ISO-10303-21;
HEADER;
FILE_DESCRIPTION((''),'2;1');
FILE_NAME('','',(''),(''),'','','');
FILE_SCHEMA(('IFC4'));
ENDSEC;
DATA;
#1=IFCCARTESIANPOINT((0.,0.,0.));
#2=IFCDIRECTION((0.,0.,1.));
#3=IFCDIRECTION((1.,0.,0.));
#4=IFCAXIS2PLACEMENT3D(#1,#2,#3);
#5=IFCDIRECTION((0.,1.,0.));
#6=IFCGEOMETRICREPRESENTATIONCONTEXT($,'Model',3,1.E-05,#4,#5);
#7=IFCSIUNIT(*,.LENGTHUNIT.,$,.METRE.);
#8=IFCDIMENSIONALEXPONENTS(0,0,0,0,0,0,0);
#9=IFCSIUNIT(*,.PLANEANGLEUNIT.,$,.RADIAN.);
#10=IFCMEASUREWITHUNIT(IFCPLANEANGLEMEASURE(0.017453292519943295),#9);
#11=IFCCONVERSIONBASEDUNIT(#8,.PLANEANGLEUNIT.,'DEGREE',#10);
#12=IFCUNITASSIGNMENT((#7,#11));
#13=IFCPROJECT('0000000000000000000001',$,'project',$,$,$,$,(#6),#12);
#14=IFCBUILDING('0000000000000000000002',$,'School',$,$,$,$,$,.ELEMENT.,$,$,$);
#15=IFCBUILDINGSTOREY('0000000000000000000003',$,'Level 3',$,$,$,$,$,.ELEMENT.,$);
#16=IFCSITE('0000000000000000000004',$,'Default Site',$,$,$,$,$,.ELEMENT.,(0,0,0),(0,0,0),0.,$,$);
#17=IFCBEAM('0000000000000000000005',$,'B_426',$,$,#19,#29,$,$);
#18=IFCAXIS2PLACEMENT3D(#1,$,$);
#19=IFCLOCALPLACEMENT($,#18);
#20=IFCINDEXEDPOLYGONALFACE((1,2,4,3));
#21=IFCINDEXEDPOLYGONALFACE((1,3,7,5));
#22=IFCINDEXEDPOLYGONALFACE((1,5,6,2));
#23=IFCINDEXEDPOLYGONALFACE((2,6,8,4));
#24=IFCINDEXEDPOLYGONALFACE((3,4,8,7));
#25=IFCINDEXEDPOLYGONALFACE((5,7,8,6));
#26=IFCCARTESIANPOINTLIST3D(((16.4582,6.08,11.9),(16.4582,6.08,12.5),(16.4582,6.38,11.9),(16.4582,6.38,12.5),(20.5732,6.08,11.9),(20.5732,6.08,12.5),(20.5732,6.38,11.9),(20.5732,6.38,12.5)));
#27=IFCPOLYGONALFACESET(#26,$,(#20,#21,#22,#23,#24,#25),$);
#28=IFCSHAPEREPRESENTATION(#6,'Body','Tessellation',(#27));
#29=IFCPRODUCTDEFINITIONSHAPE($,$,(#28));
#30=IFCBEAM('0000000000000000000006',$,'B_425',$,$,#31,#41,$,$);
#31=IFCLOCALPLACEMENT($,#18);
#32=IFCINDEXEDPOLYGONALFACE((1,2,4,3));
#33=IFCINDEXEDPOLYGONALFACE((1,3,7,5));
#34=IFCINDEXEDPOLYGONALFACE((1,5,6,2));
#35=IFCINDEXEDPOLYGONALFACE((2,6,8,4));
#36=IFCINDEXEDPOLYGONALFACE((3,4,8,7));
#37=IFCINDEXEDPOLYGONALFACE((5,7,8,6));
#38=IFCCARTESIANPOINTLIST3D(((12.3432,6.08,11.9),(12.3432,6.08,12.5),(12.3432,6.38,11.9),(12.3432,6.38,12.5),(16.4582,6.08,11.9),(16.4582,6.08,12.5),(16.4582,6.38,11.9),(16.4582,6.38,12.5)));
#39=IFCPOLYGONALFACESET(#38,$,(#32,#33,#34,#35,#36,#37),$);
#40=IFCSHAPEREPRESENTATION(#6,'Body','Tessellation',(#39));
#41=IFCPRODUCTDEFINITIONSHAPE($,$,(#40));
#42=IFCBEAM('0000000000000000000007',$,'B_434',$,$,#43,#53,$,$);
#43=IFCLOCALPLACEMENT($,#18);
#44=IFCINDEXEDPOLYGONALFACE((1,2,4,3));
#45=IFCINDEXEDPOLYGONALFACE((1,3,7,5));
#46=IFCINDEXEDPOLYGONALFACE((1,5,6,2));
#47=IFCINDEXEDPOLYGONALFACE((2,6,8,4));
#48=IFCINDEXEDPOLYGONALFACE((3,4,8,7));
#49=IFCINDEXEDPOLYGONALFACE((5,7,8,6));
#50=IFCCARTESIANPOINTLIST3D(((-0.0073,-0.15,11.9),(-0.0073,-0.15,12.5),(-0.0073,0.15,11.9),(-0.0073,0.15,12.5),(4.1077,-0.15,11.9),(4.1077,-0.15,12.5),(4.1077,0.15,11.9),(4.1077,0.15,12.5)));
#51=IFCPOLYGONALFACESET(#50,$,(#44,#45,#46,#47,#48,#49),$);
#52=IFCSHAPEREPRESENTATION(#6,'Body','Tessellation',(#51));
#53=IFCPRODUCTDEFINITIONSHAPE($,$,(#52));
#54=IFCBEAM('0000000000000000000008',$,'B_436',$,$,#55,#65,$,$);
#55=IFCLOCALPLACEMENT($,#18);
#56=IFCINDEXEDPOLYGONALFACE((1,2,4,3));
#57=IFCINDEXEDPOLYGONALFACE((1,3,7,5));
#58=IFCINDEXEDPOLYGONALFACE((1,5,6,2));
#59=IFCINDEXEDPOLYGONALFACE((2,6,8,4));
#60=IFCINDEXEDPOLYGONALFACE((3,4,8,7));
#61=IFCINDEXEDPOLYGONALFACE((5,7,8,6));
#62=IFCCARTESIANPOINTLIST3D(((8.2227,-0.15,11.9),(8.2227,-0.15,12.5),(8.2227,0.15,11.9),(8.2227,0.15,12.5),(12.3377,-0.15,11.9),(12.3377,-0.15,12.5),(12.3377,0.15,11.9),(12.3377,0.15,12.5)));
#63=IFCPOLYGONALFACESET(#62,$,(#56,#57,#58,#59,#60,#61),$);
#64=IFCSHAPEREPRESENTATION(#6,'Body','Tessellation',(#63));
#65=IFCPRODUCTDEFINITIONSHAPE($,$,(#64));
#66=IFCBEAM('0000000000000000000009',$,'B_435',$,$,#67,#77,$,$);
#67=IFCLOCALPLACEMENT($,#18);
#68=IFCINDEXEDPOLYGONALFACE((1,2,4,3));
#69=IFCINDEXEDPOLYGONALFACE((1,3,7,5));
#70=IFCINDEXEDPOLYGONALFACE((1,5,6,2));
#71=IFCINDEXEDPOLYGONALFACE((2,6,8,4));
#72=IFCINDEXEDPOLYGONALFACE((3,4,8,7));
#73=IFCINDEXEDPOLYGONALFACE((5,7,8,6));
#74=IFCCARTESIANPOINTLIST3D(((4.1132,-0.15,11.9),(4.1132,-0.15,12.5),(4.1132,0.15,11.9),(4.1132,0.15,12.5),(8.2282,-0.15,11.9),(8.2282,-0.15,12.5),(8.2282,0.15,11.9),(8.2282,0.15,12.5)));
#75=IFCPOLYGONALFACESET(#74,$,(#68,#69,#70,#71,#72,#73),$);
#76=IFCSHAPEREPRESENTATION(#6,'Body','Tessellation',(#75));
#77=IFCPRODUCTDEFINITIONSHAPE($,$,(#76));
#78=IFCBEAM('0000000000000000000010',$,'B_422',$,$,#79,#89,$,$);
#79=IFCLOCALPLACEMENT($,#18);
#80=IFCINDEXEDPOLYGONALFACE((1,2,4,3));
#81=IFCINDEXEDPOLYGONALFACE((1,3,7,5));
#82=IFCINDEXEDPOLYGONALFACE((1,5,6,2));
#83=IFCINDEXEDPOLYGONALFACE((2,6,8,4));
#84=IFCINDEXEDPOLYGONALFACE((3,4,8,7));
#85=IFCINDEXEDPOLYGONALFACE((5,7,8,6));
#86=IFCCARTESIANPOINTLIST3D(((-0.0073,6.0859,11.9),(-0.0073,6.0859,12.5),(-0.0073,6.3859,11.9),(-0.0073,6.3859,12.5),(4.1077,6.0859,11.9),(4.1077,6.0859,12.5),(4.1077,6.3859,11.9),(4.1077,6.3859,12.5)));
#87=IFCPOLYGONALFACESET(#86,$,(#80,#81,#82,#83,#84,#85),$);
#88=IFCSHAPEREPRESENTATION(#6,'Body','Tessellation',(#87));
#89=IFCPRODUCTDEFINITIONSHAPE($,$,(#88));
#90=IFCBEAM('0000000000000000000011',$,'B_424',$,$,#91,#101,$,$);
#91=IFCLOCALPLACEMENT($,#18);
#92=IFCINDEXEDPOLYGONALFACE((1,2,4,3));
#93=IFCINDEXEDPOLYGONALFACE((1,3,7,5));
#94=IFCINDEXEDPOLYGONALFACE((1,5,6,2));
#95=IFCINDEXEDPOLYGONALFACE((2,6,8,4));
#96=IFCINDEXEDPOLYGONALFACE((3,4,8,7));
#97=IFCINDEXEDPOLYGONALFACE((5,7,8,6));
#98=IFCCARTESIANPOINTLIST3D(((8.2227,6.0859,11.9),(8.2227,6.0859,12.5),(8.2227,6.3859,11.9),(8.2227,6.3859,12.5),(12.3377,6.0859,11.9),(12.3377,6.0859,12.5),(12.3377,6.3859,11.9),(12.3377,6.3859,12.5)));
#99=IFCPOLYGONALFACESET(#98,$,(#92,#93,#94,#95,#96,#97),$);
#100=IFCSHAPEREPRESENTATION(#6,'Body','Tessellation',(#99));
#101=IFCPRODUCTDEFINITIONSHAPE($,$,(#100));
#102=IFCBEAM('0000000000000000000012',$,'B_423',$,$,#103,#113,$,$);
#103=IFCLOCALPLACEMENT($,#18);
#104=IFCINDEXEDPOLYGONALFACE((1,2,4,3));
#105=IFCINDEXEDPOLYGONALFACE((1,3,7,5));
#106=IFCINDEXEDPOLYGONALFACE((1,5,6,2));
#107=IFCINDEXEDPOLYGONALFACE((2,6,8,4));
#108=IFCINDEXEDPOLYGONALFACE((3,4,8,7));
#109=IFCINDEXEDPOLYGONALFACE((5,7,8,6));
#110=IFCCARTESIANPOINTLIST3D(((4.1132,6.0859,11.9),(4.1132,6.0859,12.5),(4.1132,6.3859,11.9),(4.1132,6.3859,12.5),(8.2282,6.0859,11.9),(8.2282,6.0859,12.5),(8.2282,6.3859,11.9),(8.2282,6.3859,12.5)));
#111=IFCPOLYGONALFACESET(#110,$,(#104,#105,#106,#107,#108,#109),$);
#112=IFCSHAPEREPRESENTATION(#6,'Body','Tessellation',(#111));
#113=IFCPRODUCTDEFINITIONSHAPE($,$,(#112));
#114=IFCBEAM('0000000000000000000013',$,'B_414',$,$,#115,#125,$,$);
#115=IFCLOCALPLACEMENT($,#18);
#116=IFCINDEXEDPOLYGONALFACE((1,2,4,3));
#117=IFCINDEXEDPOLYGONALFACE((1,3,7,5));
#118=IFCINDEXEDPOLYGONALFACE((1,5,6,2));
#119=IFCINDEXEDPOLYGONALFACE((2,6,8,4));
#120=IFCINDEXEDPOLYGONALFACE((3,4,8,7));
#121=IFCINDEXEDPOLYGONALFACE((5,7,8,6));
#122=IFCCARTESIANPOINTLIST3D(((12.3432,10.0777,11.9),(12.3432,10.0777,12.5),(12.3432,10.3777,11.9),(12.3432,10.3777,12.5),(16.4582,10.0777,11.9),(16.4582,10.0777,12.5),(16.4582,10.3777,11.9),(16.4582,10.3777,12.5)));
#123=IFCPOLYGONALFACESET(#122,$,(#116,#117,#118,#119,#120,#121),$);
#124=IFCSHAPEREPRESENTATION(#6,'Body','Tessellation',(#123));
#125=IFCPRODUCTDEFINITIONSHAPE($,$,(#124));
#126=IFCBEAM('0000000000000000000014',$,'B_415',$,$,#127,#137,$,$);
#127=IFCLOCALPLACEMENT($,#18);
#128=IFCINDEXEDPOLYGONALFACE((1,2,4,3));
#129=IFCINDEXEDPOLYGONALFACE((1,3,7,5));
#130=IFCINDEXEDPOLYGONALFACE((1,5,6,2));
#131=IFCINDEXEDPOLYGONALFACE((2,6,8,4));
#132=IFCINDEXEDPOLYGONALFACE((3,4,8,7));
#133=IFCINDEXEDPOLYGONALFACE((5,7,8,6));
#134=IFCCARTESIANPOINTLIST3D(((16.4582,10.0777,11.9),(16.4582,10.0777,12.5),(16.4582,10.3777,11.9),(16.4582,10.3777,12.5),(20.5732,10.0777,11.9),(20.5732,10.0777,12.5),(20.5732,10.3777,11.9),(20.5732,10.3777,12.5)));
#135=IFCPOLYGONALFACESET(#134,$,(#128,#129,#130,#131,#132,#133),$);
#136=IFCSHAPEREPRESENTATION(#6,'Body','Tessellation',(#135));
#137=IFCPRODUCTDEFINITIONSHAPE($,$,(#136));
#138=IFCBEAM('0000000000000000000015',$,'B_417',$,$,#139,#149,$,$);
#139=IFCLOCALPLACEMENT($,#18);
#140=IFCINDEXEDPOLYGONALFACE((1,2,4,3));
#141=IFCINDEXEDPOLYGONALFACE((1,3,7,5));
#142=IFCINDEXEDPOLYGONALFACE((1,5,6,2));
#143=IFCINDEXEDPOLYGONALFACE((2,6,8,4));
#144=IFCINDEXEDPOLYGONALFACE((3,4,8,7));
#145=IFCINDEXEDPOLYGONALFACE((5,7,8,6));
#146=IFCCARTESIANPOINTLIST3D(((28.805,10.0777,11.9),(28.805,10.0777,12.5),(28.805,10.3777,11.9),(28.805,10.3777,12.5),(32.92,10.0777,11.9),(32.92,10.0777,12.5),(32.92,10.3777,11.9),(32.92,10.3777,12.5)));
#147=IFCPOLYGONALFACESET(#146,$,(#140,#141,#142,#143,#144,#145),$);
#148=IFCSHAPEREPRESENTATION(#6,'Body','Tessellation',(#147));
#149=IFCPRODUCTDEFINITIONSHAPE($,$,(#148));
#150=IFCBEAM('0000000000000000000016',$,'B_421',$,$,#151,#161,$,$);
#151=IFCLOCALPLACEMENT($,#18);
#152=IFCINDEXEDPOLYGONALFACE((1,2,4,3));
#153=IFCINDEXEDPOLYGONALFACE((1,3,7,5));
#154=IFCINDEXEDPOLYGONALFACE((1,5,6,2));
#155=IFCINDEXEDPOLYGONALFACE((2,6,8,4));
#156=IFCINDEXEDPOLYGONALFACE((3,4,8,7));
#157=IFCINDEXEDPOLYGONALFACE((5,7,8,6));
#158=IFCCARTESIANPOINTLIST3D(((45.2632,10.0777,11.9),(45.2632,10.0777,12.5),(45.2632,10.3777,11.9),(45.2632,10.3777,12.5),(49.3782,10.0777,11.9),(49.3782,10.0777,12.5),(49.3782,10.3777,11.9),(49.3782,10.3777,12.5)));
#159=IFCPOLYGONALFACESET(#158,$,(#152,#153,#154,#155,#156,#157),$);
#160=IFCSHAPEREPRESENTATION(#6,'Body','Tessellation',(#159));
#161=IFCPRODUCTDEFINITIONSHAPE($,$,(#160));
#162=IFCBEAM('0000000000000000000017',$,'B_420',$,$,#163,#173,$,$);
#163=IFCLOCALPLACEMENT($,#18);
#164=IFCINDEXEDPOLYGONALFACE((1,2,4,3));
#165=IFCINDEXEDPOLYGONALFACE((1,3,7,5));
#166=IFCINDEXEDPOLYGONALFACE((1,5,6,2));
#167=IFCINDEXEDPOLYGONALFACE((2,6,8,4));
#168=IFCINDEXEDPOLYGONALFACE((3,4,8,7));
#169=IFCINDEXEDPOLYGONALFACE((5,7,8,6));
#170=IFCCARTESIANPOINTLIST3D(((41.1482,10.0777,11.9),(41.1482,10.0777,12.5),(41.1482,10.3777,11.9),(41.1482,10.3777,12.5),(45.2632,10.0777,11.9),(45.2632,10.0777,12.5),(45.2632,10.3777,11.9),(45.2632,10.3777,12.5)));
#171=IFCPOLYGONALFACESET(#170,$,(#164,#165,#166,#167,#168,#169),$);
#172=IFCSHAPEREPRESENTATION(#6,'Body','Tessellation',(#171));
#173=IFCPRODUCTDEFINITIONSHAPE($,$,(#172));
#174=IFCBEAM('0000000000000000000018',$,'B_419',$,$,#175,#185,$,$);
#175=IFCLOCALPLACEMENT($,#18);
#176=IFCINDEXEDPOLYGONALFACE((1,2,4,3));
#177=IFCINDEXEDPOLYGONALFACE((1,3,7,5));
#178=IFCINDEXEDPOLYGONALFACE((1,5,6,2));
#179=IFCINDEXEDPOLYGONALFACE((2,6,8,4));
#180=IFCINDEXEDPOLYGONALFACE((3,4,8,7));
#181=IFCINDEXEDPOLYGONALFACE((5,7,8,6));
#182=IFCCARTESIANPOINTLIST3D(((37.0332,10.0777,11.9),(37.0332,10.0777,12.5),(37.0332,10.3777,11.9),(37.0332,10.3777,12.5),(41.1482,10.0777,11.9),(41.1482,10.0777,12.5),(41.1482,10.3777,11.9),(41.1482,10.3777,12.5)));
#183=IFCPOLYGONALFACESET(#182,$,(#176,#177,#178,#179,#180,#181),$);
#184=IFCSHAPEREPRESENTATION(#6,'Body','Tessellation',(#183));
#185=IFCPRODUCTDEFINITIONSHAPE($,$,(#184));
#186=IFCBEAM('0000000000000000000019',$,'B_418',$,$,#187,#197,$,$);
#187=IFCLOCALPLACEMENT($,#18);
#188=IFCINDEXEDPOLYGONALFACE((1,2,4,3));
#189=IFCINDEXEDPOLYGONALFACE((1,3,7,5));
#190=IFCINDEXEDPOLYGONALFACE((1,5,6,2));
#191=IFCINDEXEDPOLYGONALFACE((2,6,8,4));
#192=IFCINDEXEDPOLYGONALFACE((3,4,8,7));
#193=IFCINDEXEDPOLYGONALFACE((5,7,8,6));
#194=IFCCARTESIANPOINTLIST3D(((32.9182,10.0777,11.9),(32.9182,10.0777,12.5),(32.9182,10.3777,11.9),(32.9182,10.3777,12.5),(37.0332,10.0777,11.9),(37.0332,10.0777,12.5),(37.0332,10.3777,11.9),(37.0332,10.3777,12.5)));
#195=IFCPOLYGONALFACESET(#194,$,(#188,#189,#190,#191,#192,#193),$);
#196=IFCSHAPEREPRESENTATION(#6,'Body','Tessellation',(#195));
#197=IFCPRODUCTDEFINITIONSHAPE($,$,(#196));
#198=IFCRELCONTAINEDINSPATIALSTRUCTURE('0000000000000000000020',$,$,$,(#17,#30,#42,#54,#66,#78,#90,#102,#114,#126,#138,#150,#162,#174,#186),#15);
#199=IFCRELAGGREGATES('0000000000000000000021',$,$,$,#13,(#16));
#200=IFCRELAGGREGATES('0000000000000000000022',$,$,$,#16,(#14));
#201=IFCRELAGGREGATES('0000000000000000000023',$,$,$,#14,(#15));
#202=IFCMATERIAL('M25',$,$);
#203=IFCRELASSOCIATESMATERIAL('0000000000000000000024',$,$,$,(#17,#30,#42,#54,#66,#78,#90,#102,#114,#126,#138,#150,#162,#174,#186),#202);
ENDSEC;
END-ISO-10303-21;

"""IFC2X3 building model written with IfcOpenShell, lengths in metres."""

from ifc_helpers import new_model, entity, si_unit, converted_unit, direction, frame, frame_2d, origin_with_axes, place, context, project, spatial, rectangle, extrude, material, element, save


model = new_model("IFC2X3")

# Units and contexts
model_context = context("Model", 3, precision=1e-05, world=origin_with_axes(), true_north=direction((0.0, 1.0, 0.0)))
ifc_project = project(units=[si_unit("LENGTHUNIT", "METRE"), converted_unit("PLANEANGLEUNIT", "DEGREE", entity("IfcPlaneAngleMeasure", 0.017453292519943295), si_unit("PLANEANGLEUNIT", "RADIAN"), dimensions=[0, 0, 0, 0, 0, 0, 0])], contexts=[model_context])

# Site, building, storey
site = spatial("IfcSite", under=ifc_project, Name="Default Site", CompositionType="ELEMENT", RefLatitude=(0, 0, 0), RefLongitude=(0, 0, 0), RefElevation=0.0)
building = spatial("IfcBuilding", under=site, Name="School", CompositionType="ELEMENT")
storey = spatial("IfcBuildingStorey", under=building, Name="Level 3", CompositionType="ELEMENT")

# Beams
ifc_material = material(Name="M25")
placement = place(None, origin_with_axes())
element("IfcBeam", 1, at=placement, inside=storey, material=ifc_material, Name="B_426", context=model_context, shape_type="SweptSolid", body=[
    extrude(rectangle(XDim=0.3, YDim=0.6, at=frame_2d((0.0, 0.0), x_axis=(0.0, 1.0, 0.0))), frame((16.4582, 6.23, 12.2), z_axis=(1.0, 0.0, 0.0), x_axis=(0.0, 0.0, -1.0)), (0.0, 0.0, 1.0), 4.115),
])
element("IfcBeam", 2, at=placement, inside=storey, material=ifc_material, Name="B_425", context=model_context, shape_type="SweptSolid", body=[
    extrude(rectangle(XDim=0.3, YDim=0.6, at=frame_2d((0.0, 0.0), x_axis=(0.0, 1.0, 0.0))), frame((12.3432, 6.23, 12.2), z_axis=(1.0, 0.0, 0.0), x_axis=(0.0, 0.0, -1.0)), (0.0, 0.0, 1.0), 4.115),
])
element("IfcBeam", 3, at=placement, inside=storey, material=ifc_material, Name="B_434", context=model_context, shape_type="SweptSolid", body=[
    extrude(rectangle(XDim=0.3, YDim=0.6, at=frame_2d((0.0, 0.0), x_axis=(0.0, 1.0, 0.0))), frame((-0.0073, 0.0, 12.2), z_axis=(1.0, 0.0, 0.0), x_axis=(0.0, 0.0, -1.0)), (0.0, 0.0, 1.0), 4.115),
])
element("IfcBeam", 4, at=placement, inside=storey, material=ifc_material, Name="B_436", context=model_context, shape_type="SweptSolid", body=[
    extrude(rectangle(XDim=0.3, YDim=0.6, at=frame_2d((0.0, 0.0), x_axis=(0.0, 1.0, 0.0))), frame((8.2227, 0.0, 12.2), z_axis=(1.0, 0.0, 0.0), x_axis=(0.0, 0.0, -1.0)), (0.0, 0.0, 1.0), 4.115),
])
element("IfcBeam", 5, at=placement, inside=storey, material=ifc_material, Name="B_435", context=model_context, shape_type="SweptSolid", body=[
    extrude(rectangle(XDim=0.3, YDim=0.6, at=frame_2d((0.0, 0.0), x_axis=(0.0, 1.0, 0.0))), frame((4.1132, 0.0, 12.2), z_axis=(1.0, 0.0, 0.0), x_axis=(0.0, 0.0, -1.0)), (0.0, 0.0, 1.0), 4.115),
])
element("IfcBeam", 6, at=placement, inside=storey, material=ifc_material, Name="B_422", context=model_context, shape_type="SweptSolid", body=[
    extrude(rectangle(XDim=0.3, YDim=0.6, at=frame_2d((0.0, 0.0), x_axis=(0.0, 1.0, 0.0))), frame((-0.0073, 6.2359, 12.2), z_axis=(1.0, 0.0, 0.0), x_axis=(0.0, 0.0, -1.0)), (0.0, 0.0, 1.0), 4.115),
])
element("IfcBeam", 7, at=placement, inside=storey, material=ifc_material, Name="B_424", context=model_context, shape_type="SweptSolid", body=[
    extrude(rectangle(XDim=0.3, YDim=0.6, at=frame_2d((0.0, 0.0), x_axis=(0.0, 1.0, 0.0))), frame((8.2227, 6.2359, 12.2), z_axis=(1.0, 0.0, 0.0), x_axis=(0.0, 0.0, -1.0)), (0.0, 0.0, 1.0), 4.115),
])
element("IfcBeam", 8, at=placement, inside=storey, material=ifc_material, Name="B_423", context=model_context, shape_type="SweptSolid", body=[
    extrude(rectangle(XDim=0.3, YDim=0.6, at=frame_2d((0.0, 0.0), x_axis=(0.0, 1.0, 0.0))), frame((4.1132, 6.2359, 12.2), z_axis=(1.0, 0.0, 0.0), x_axis=(0.0, 0.0, -1.0)), (0.0, 0.0, 1.0), 4.115),
])
element("IfcBeam", 9, at=placement, inside=storey, material=ifc_material, Name="B_414", context=model_context, shape_type="SweptSolid", body=[
    extrude(rectangle(XDim=0.3, YDim=0.6, at=frame_2d((0.0, 0.0), x_axis=(0.0, 1.0, 0.0))), frame((12.3432, 10.2277, 12.2), z_axis=(1.0, 0.0, 0.0), x_axis=(0.0, 0.0, -1.0)), (0.0, 0.0, 1.0), 4.115),
])
element("IfcBeam", 10, at=placement, inside=storey, material=ifc_material, Name="B_415", context=model_context, shape_type="SweptSolid", body=[
    extrude(rectangle(XDim=0.3, YDim=0.6, at=frame_2d((0.0, 0.0), x_axis=(0.0, 1.0, 0.0))), frame((16.4582, 10.2277, 12.2), z_axis=(1.0, 0.0, 0.0), x_axis=(0.0, 0.0, -1.0)), (0.0, 0.0, 1.0), 4.115),
])
element("IfcBeam", 11, at=placement, inside=storey, material=ifc_material, Name="B_417", context=model_context, shape_type="SweptSolid", body=[
    extrude(rectangle(XDim=0.3, YDim=0.6, at=frame_2d((0.0, 0.0), x_axis=(0.0, 1.0, 0.0))), frame((28.805, 10.2277, 12.2), z_axis=(1.0, 0.0, 0.0), x_axis=(0.0, 0.0, -1.0)), (0.0, 0.0, 1.0), 4.115),
])
element("IfcBeam", 12, at=placement, inside=storey, material=ifc_material, Name="B_421", context=model_context, shape_type="SweptSolid", body=[
    extrude(rectangle(XDim=0.3, YDim=0.6, at=frame_2d((0.0, 0.0), x_axis=(0.0, 1.0, 0.0))), frame((45.2632, 10.2277, 12.2), z_axis=(1.0, 0.0, 0.0), x_axis=(0.0, 0.0, -1.0)), (0.0, 0.0, 1.0), 4.115),
])
element("IfcBeam", 13, at=placement, inside=storey, material=ifc_material, Name="B_420", context=model_context, shape_type="SweptSolid", body=[
    extrude(rectangle(XDim=0.3, YDim=0.6, at=frame_2d((0.0, 0.0), x_axis=(0.0, 1.0, 0.0))), frame((41.1482, 10.2277, 12.2), z_axis=(1.0, 0.0, 0.0), x_axis=(0.0, 0.0, -1.0)), (0.0, 0.0, 1.0), 4.115),
])
element("IfcBeam", 14, at=placement, inside=storey, material=ifc_material, Name="B_419", context=model_context, shape_type="SweptSolid", body=[
    extrude(rectangle(XDim=0.3, YDim=0.6, at=frame_2d((0.0, 0.0), x_axis=(0.0, 1.0, 0.0))), frame((37.0332, 10.2277, 12.2), z_axis=(1.0, 0.0, 0.0), x_axis=(0.0, 0.0, -1.0)), (0.0, 0.0, 1.0), 4.115),
])
element("IfcBeam", 15, at=placement, inside=storey, material=ifc_material, Name="B_418", context=model_context, shape_type="SweptSolid", body=[
    extrude(rectangle(XDim=0.3, YDim=0.6, at=frame_2d((0.0, 0.0), x_axis=(0.0, 1.0, 0.0))), frame((32.9182, 10.2277, 12.2), z_axis=(1.0, 0.0, 0.0), x_axis=(0.0, 0.0, -1.0)), (0.0, 0.0, 1.0), 4.115),
])

save(model, "model.ifc")
